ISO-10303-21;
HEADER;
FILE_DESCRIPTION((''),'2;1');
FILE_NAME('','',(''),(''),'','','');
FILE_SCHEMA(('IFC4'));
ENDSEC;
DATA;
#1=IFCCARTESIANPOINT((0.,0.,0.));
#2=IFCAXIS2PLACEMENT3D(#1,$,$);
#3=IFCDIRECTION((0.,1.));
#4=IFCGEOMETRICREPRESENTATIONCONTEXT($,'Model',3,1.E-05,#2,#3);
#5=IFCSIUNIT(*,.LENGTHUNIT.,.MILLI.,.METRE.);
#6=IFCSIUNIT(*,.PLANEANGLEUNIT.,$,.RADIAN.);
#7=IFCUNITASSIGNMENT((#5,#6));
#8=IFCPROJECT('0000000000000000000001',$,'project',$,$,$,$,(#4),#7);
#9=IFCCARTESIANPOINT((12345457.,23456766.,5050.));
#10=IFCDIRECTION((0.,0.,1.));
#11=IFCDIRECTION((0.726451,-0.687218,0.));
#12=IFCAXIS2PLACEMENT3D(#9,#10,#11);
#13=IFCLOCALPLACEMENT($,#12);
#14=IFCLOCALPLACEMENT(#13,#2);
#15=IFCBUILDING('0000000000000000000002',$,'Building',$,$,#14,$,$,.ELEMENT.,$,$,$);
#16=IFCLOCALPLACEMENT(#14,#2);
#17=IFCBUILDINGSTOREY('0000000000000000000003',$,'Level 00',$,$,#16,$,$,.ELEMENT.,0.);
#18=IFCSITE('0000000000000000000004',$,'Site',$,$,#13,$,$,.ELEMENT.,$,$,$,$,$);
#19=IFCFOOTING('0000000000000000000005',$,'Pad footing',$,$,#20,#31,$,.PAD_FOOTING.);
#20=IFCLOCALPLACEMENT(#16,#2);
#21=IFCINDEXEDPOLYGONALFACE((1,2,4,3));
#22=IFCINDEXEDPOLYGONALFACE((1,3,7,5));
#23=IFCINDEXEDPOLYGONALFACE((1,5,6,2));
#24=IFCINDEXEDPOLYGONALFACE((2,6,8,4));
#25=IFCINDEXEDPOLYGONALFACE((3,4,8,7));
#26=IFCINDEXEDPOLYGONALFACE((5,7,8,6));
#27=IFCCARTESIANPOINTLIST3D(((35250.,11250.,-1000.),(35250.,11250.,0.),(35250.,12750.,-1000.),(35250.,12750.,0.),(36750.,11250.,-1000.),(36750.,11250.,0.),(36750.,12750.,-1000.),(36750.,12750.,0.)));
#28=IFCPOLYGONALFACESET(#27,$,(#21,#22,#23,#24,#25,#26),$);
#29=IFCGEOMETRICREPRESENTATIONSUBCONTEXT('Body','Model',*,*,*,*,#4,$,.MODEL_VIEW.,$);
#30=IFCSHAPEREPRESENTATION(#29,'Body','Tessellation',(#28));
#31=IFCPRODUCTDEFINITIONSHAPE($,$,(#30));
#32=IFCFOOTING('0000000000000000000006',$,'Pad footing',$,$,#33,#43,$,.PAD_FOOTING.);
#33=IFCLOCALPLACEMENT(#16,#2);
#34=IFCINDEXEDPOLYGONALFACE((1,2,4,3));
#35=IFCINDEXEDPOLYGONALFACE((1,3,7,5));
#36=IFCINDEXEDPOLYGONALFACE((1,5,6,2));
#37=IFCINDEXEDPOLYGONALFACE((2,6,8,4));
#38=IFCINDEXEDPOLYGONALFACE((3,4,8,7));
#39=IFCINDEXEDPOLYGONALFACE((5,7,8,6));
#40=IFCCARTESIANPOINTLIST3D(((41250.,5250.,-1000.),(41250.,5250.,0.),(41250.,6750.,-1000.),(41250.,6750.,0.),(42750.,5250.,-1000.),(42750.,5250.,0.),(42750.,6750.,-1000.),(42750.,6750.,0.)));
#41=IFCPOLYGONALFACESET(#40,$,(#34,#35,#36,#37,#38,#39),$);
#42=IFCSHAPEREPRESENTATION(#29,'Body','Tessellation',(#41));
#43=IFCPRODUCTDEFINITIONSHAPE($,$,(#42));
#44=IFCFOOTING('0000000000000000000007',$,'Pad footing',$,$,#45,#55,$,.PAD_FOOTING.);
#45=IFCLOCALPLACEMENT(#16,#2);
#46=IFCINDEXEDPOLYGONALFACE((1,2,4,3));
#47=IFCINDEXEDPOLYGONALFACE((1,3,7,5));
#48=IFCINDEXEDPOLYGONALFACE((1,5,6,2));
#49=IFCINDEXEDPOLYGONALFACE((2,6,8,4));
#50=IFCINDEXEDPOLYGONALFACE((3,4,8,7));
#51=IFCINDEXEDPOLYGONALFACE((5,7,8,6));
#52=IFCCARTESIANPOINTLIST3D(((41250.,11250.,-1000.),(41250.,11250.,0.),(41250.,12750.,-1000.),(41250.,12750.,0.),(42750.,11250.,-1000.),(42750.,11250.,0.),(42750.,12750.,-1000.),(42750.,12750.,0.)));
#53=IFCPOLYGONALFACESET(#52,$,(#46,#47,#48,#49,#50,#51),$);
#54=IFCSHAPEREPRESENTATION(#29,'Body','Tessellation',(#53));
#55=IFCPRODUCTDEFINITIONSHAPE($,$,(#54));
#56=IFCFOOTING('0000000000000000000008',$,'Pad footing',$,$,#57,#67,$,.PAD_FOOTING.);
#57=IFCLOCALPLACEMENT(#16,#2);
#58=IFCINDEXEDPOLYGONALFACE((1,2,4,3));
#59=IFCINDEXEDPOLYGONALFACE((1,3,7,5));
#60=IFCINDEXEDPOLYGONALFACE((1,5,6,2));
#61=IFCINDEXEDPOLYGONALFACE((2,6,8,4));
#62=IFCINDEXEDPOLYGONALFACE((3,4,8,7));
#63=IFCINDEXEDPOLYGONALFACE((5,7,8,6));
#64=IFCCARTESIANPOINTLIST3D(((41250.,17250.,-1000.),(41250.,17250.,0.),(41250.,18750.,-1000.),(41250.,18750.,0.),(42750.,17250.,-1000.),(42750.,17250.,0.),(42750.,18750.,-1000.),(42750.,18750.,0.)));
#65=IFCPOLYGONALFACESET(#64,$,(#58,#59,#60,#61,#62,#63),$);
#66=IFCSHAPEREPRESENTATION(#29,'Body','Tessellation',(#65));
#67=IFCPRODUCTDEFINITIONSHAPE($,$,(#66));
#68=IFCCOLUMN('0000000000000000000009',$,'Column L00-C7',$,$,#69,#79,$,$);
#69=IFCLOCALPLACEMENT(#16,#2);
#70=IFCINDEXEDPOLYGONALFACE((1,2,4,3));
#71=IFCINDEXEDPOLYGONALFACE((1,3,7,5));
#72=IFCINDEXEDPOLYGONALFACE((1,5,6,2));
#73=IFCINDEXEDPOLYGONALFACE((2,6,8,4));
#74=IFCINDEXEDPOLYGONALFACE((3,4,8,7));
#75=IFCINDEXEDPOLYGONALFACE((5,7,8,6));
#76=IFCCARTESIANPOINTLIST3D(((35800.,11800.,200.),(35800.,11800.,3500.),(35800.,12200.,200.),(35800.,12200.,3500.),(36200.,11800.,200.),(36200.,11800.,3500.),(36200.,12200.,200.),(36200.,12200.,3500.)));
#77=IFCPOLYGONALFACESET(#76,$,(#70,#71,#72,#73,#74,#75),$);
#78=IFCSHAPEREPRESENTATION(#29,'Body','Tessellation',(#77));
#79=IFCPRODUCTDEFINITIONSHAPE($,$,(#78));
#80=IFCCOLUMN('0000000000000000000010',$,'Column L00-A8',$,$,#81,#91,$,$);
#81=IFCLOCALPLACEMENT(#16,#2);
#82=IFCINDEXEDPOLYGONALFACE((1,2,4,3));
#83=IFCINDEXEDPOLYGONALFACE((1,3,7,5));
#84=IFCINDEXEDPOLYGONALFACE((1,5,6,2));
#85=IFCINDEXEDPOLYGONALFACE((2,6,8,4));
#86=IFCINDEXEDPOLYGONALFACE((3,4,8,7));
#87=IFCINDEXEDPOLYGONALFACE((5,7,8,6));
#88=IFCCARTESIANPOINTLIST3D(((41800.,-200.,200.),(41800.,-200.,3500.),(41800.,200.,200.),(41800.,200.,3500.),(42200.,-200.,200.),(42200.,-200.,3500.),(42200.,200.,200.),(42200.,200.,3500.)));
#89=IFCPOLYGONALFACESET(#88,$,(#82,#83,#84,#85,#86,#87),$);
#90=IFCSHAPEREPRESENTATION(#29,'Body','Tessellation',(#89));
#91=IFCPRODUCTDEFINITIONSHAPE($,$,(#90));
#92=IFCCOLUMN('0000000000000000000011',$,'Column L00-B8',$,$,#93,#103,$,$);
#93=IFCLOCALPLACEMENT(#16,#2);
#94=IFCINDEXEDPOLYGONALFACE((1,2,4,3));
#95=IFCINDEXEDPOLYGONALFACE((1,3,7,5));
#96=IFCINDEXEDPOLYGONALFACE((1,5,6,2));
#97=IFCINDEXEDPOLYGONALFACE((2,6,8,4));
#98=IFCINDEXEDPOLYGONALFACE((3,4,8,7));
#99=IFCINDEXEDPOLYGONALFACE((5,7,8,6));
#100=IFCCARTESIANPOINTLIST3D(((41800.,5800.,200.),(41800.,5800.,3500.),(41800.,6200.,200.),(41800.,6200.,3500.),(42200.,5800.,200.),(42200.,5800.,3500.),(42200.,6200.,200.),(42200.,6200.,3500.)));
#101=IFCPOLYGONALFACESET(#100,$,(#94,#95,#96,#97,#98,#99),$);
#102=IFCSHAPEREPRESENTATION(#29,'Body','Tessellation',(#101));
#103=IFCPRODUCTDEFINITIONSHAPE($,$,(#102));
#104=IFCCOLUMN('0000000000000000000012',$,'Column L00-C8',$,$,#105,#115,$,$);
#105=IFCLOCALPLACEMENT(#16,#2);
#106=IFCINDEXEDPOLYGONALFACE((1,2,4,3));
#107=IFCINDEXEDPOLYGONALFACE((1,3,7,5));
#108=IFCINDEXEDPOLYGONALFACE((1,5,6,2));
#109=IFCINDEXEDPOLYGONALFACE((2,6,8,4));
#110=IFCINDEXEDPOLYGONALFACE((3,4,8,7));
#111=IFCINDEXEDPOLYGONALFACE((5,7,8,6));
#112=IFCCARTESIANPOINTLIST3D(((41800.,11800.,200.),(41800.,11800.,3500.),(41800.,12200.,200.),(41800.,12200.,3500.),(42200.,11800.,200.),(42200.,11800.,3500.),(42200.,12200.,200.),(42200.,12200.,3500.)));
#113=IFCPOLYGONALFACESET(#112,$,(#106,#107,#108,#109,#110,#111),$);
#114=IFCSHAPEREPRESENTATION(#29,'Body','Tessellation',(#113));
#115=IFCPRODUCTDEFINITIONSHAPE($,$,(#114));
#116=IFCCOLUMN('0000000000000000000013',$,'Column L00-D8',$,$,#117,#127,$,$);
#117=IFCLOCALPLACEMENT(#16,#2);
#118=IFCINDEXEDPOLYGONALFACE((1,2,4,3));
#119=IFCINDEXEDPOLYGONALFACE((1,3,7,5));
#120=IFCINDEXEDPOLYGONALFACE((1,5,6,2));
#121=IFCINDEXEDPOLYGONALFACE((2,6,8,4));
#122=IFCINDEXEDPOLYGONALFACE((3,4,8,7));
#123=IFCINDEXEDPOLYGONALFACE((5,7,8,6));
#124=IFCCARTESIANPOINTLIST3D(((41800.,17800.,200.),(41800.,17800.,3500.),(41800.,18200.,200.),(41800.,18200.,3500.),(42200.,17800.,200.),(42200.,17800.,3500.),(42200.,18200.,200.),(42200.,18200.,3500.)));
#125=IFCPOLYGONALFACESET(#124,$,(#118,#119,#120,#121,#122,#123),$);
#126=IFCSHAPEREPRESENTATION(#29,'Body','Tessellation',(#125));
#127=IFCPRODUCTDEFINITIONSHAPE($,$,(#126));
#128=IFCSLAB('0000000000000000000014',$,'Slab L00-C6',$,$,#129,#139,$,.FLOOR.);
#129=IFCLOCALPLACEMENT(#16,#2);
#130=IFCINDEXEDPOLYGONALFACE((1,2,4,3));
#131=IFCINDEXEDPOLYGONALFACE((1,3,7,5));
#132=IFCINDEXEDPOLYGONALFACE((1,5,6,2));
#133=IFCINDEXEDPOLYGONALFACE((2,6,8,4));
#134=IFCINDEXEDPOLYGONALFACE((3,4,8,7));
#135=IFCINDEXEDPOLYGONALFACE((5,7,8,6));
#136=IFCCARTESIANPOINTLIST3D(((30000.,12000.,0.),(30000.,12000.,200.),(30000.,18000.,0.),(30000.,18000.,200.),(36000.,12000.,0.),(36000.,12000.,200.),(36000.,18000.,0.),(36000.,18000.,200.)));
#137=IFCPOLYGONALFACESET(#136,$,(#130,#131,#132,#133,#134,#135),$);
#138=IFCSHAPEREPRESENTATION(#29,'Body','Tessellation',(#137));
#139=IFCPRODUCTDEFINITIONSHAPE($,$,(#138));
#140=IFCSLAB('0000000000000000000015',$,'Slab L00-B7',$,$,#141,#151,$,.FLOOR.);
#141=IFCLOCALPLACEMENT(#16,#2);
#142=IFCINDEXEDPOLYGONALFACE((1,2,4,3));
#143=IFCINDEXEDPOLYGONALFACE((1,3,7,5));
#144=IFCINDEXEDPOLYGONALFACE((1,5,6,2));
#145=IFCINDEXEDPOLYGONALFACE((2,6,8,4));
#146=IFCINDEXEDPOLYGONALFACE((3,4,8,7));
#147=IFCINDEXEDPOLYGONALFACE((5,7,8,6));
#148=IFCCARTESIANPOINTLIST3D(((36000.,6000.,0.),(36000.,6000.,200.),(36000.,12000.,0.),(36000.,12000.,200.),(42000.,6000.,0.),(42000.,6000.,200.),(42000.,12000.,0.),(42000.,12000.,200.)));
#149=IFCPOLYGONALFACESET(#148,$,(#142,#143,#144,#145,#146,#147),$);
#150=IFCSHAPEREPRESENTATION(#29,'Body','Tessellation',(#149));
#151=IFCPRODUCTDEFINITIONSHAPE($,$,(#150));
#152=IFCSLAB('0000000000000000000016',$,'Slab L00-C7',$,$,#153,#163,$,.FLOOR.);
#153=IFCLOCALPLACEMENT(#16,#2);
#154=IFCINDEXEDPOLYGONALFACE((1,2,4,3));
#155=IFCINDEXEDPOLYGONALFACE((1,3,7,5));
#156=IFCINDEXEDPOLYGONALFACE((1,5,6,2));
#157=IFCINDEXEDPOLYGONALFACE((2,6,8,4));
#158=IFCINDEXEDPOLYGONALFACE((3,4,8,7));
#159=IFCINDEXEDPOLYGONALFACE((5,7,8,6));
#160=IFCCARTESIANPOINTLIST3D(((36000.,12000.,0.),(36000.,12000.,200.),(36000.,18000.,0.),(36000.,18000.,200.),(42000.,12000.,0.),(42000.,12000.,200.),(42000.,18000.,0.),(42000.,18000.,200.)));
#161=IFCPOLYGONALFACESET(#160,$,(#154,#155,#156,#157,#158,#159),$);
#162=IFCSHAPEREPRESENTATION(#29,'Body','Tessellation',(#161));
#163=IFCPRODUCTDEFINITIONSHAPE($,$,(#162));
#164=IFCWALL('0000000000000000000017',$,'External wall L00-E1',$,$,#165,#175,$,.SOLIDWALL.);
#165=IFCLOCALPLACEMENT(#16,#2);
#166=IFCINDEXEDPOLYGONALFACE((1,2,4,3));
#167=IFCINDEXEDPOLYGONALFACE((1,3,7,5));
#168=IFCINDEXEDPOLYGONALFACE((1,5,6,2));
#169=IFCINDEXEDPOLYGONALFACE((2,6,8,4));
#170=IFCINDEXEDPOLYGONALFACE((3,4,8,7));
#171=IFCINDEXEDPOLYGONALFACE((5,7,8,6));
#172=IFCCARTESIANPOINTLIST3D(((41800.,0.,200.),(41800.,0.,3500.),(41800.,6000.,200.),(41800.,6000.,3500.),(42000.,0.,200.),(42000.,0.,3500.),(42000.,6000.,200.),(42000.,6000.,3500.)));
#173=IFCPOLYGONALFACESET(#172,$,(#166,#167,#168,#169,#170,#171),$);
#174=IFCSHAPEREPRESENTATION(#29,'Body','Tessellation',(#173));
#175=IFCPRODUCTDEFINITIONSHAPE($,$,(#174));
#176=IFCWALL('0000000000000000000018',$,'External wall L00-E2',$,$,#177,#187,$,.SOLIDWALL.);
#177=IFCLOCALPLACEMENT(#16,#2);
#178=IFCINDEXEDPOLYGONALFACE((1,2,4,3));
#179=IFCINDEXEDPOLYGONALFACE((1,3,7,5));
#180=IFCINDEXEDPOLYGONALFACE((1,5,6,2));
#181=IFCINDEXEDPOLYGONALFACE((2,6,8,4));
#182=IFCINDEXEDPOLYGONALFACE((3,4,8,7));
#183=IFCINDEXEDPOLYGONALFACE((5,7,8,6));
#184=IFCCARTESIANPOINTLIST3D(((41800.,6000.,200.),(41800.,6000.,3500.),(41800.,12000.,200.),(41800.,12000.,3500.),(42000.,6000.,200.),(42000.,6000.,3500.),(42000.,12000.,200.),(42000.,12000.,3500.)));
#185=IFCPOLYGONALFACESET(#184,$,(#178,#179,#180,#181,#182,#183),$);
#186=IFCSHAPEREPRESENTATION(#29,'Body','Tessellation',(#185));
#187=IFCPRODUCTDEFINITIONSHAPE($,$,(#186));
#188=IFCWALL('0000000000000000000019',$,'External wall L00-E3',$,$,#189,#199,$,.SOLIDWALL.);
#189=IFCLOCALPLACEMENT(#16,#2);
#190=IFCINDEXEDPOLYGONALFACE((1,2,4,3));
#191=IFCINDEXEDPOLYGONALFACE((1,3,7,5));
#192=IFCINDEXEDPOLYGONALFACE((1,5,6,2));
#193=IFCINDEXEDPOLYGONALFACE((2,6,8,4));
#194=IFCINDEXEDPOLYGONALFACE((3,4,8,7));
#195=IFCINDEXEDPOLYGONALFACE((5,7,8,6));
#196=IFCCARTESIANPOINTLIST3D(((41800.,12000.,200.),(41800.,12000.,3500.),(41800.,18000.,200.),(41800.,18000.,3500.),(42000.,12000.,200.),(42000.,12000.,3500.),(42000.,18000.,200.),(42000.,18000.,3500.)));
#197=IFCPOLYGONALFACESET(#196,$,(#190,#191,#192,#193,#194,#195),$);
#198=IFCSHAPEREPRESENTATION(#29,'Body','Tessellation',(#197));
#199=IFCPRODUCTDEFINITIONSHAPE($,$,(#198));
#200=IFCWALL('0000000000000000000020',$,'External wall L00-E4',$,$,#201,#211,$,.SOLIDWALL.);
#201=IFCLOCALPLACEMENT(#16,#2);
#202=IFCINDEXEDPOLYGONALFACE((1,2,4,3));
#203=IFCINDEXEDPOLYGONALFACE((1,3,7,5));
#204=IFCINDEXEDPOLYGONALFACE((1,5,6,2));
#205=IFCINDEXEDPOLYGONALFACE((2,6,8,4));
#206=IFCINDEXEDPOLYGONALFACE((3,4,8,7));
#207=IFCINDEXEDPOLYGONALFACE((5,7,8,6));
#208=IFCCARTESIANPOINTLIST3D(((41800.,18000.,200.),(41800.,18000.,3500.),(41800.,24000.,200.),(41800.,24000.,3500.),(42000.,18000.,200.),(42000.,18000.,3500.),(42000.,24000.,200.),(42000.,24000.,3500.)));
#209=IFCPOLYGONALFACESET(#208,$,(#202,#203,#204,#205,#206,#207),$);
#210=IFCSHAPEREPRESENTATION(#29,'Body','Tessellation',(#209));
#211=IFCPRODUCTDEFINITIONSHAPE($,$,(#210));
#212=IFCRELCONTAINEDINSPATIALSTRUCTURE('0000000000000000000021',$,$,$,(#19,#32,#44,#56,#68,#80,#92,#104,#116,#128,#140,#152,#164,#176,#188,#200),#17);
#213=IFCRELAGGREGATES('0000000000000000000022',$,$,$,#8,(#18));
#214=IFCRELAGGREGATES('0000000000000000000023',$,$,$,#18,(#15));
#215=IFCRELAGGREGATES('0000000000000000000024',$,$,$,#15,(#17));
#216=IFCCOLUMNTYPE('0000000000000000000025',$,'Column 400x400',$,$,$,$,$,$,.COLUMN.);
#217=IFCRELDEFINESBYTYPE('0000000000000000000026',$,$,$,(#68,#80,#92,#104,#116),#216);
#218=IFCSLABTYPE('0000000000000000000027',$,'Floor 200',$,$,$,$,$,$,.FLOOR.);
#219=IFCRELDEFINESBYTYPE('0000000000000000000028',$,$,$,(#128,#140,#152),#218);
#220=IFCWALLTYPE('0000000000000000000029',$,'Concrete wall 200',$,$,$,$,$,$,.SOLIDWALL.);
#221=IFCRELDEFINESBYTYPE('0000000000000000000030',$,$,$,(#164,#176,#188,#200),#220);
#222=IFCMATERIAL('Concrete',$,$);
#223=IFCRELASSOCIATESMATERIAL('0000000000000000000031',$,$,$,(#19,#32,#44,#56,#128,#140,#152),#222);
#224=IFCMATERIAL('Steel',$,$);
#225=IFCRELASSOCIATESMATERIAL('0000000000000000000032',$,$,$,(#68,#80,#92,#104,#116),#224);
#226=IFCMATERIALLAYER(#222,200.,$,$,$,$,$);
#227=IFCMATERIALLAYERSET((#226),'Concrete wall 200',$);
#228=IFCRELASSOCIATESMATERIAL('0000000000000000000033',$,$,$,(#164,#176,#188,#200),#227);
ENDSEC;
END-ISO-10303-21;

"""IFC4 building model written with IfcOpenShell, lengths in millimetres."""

from ifc_helpers import new_model, si_unit, direction, frame, origin, place, context, subcontext, project, spatial, rectangle, extrude, material, layer, layer_set, layer_usage, type_object, element, save


model = new_model("IFC4")

# Units and contexts
model_context = context("Model", 3, precision=1e-05, world=origin(), true_north=direction((0.0, 1.0)))
body_context = subcontext(model_context, "Body", "Model", "MODEL_VIEW")
ifc_project = project(units=[si_unit("LENGTHUNIT", "METRE", prefix="MILLI"), si_unit("PLANEANGLEUNIT", "RADIAN")], contexts=[model_context])

# Site, building, storey
site_placement = place(None, frame((12345457.0, 23456766.0, 5050.0), z_axis=(0.0, 0.0, 1.0), x_axis=(0.726451, -0.687218, 0.0)))
site = spatial("IfcSite", under=ifc_project, at=site_placement, Name="Site", CompositionType="ELEMENT")
building_placement = place(site_placement, origin())
building = spatial("IfcBuilding", under=site, at=building_placement, Name="Building", CompositionType="ELEMENT")
storey_placement = place(building_placement, origin())
storey = spatial("IfcBuildingStorey", under=building, at=storey_placement, Name="Level 00", CompositionType="ELEMENT", Elevation=0.0)

# Footings
ifc_material_1 = material(Name="Concrete")
for number, where, name in (
    (1, (35250.0, 11250.0, -1000.0), "Pad footing"),
    (2, (41250.0, 5250.0, -1000.0), "Pad footing"),
    (3, (41250.0, 11250.0, -1000.0), "Pad footing"),
    (4, (41250.0, 17250.0, -1000.0), "Pad footing"),
):
    element("IfcFooting", number, at=place(storey_placement, frame(where)), inside=storey, material=ifc_material_1, Name=name, PredefinedType="PAD_FOOTING", context=body_context, shape_type="SweptSolid", body=[
        extrude(rectangle(XDim=1500.0, YDim=1500.0), frame((750.0, 750.0, 0.0)), (0.0, 0.0, 1.0), 1000.0),
    ])

# Columns
ifc_material_2 = material(Name="Steel")
column_type = type_object("IfcColumnType", Name="Column 400x400", PredefinedType="COLUMN")
for number, where, name in (
    (5, (35800.0, 11800.0, 200.0), "Column L00-C7"),
    (6, (41800.0, -200.0, 200.0), "Column L00-A8"),
    (7, (41800.0, 5800.0, 200.0), "Column L00-B8"),
    (8, (41800.0, 11800.0, 200.0), "Column L00-C8"),
    (9, (41800.0, 17800.0, 200.0), "Column L00-D8"),
):
    element("IfcColumn", number, at=place(storey_placement, frame(where)), inside=storey, type_object=column_type, material=ifc_material_2, Name=name, context=body_context, shape_type="SweptSolid", body=[
        extrude(rectangle(XDim=400.0, YDim=400.0), frame((200.0, 200.0, 0.0)), (0.0, 0.0, 1.0), 3300.0),
    ])

# Slabs
slab_type = type_object("IfcSlabType", Name="Floor 200", PredefinedType="FLOOR")
for number, where, name in (
    (10, (30000.0, 12000.0, 0.0), "Slab L00-C6"),
    (11, (36000.0, 6000.0, 0.0), "Slab L00-B7"),
    (12, (36000.0, 12000.0, 0.0), "Slab L00-C7"),
):
    element("IfcSlab", number, at=place(storey_placement, frame(where)), inside=storey, type_object=slab_type, material=ifc_material_1, Name=name, PredefinedType="FLOOR", context=body_context, shape_type="SweptSolid", body=[
        extrude(rectangle(XDim=6000.0, YDim=6000.0), frame((3000.0, 3000.0, 0.0)), (0.0, 0.0, 1.0), 200.0),
    ])

# Walls
ifc_layer_1 = layer(ifc_material_1, 200.0)
ifc_layer_set_1 = layer_set([ifc_layer_1], Name="Concrete wall 200")
ifc_layer_usage_1 = layer_usage(ifc_layer_set_1, "AXIS2", "POSITIVE", 0.0)
wall_type_1 = type_object("IfcWallType", Name="Concrete wall 200", PredefinedType="SOLIDWALL")
for number, where, name in (
    (13, (41800.0, 0.0, 200.0), "External wall L00-E1"),
    (14, (41800.0, 6000.0, 200.0), "External wall L00-E2"),
    (15, (41800.0, 12000.0, 200.0), "External wall L00-E3"),
    (16, (41800.0, 18000.0, 200.0), "External wall L00-E4"),
):
    element("IfcWall", number, at=place(storey_placement, frame(where)), inside=storey, type_object=wall_type_1, material=ifc_layer_usage_1, Name=name, PredefinedType="SOLIDWALL", context=body_context, shape_type="SweptSolid", body=[
        extrude(rectangle(XDim=200.0, YDim=6000.0), frame((100.0, 3000.0, 0.0)), (0.0, 0.0, 1.0), 3300.0),
    ])

save(model, "model.ifc")
